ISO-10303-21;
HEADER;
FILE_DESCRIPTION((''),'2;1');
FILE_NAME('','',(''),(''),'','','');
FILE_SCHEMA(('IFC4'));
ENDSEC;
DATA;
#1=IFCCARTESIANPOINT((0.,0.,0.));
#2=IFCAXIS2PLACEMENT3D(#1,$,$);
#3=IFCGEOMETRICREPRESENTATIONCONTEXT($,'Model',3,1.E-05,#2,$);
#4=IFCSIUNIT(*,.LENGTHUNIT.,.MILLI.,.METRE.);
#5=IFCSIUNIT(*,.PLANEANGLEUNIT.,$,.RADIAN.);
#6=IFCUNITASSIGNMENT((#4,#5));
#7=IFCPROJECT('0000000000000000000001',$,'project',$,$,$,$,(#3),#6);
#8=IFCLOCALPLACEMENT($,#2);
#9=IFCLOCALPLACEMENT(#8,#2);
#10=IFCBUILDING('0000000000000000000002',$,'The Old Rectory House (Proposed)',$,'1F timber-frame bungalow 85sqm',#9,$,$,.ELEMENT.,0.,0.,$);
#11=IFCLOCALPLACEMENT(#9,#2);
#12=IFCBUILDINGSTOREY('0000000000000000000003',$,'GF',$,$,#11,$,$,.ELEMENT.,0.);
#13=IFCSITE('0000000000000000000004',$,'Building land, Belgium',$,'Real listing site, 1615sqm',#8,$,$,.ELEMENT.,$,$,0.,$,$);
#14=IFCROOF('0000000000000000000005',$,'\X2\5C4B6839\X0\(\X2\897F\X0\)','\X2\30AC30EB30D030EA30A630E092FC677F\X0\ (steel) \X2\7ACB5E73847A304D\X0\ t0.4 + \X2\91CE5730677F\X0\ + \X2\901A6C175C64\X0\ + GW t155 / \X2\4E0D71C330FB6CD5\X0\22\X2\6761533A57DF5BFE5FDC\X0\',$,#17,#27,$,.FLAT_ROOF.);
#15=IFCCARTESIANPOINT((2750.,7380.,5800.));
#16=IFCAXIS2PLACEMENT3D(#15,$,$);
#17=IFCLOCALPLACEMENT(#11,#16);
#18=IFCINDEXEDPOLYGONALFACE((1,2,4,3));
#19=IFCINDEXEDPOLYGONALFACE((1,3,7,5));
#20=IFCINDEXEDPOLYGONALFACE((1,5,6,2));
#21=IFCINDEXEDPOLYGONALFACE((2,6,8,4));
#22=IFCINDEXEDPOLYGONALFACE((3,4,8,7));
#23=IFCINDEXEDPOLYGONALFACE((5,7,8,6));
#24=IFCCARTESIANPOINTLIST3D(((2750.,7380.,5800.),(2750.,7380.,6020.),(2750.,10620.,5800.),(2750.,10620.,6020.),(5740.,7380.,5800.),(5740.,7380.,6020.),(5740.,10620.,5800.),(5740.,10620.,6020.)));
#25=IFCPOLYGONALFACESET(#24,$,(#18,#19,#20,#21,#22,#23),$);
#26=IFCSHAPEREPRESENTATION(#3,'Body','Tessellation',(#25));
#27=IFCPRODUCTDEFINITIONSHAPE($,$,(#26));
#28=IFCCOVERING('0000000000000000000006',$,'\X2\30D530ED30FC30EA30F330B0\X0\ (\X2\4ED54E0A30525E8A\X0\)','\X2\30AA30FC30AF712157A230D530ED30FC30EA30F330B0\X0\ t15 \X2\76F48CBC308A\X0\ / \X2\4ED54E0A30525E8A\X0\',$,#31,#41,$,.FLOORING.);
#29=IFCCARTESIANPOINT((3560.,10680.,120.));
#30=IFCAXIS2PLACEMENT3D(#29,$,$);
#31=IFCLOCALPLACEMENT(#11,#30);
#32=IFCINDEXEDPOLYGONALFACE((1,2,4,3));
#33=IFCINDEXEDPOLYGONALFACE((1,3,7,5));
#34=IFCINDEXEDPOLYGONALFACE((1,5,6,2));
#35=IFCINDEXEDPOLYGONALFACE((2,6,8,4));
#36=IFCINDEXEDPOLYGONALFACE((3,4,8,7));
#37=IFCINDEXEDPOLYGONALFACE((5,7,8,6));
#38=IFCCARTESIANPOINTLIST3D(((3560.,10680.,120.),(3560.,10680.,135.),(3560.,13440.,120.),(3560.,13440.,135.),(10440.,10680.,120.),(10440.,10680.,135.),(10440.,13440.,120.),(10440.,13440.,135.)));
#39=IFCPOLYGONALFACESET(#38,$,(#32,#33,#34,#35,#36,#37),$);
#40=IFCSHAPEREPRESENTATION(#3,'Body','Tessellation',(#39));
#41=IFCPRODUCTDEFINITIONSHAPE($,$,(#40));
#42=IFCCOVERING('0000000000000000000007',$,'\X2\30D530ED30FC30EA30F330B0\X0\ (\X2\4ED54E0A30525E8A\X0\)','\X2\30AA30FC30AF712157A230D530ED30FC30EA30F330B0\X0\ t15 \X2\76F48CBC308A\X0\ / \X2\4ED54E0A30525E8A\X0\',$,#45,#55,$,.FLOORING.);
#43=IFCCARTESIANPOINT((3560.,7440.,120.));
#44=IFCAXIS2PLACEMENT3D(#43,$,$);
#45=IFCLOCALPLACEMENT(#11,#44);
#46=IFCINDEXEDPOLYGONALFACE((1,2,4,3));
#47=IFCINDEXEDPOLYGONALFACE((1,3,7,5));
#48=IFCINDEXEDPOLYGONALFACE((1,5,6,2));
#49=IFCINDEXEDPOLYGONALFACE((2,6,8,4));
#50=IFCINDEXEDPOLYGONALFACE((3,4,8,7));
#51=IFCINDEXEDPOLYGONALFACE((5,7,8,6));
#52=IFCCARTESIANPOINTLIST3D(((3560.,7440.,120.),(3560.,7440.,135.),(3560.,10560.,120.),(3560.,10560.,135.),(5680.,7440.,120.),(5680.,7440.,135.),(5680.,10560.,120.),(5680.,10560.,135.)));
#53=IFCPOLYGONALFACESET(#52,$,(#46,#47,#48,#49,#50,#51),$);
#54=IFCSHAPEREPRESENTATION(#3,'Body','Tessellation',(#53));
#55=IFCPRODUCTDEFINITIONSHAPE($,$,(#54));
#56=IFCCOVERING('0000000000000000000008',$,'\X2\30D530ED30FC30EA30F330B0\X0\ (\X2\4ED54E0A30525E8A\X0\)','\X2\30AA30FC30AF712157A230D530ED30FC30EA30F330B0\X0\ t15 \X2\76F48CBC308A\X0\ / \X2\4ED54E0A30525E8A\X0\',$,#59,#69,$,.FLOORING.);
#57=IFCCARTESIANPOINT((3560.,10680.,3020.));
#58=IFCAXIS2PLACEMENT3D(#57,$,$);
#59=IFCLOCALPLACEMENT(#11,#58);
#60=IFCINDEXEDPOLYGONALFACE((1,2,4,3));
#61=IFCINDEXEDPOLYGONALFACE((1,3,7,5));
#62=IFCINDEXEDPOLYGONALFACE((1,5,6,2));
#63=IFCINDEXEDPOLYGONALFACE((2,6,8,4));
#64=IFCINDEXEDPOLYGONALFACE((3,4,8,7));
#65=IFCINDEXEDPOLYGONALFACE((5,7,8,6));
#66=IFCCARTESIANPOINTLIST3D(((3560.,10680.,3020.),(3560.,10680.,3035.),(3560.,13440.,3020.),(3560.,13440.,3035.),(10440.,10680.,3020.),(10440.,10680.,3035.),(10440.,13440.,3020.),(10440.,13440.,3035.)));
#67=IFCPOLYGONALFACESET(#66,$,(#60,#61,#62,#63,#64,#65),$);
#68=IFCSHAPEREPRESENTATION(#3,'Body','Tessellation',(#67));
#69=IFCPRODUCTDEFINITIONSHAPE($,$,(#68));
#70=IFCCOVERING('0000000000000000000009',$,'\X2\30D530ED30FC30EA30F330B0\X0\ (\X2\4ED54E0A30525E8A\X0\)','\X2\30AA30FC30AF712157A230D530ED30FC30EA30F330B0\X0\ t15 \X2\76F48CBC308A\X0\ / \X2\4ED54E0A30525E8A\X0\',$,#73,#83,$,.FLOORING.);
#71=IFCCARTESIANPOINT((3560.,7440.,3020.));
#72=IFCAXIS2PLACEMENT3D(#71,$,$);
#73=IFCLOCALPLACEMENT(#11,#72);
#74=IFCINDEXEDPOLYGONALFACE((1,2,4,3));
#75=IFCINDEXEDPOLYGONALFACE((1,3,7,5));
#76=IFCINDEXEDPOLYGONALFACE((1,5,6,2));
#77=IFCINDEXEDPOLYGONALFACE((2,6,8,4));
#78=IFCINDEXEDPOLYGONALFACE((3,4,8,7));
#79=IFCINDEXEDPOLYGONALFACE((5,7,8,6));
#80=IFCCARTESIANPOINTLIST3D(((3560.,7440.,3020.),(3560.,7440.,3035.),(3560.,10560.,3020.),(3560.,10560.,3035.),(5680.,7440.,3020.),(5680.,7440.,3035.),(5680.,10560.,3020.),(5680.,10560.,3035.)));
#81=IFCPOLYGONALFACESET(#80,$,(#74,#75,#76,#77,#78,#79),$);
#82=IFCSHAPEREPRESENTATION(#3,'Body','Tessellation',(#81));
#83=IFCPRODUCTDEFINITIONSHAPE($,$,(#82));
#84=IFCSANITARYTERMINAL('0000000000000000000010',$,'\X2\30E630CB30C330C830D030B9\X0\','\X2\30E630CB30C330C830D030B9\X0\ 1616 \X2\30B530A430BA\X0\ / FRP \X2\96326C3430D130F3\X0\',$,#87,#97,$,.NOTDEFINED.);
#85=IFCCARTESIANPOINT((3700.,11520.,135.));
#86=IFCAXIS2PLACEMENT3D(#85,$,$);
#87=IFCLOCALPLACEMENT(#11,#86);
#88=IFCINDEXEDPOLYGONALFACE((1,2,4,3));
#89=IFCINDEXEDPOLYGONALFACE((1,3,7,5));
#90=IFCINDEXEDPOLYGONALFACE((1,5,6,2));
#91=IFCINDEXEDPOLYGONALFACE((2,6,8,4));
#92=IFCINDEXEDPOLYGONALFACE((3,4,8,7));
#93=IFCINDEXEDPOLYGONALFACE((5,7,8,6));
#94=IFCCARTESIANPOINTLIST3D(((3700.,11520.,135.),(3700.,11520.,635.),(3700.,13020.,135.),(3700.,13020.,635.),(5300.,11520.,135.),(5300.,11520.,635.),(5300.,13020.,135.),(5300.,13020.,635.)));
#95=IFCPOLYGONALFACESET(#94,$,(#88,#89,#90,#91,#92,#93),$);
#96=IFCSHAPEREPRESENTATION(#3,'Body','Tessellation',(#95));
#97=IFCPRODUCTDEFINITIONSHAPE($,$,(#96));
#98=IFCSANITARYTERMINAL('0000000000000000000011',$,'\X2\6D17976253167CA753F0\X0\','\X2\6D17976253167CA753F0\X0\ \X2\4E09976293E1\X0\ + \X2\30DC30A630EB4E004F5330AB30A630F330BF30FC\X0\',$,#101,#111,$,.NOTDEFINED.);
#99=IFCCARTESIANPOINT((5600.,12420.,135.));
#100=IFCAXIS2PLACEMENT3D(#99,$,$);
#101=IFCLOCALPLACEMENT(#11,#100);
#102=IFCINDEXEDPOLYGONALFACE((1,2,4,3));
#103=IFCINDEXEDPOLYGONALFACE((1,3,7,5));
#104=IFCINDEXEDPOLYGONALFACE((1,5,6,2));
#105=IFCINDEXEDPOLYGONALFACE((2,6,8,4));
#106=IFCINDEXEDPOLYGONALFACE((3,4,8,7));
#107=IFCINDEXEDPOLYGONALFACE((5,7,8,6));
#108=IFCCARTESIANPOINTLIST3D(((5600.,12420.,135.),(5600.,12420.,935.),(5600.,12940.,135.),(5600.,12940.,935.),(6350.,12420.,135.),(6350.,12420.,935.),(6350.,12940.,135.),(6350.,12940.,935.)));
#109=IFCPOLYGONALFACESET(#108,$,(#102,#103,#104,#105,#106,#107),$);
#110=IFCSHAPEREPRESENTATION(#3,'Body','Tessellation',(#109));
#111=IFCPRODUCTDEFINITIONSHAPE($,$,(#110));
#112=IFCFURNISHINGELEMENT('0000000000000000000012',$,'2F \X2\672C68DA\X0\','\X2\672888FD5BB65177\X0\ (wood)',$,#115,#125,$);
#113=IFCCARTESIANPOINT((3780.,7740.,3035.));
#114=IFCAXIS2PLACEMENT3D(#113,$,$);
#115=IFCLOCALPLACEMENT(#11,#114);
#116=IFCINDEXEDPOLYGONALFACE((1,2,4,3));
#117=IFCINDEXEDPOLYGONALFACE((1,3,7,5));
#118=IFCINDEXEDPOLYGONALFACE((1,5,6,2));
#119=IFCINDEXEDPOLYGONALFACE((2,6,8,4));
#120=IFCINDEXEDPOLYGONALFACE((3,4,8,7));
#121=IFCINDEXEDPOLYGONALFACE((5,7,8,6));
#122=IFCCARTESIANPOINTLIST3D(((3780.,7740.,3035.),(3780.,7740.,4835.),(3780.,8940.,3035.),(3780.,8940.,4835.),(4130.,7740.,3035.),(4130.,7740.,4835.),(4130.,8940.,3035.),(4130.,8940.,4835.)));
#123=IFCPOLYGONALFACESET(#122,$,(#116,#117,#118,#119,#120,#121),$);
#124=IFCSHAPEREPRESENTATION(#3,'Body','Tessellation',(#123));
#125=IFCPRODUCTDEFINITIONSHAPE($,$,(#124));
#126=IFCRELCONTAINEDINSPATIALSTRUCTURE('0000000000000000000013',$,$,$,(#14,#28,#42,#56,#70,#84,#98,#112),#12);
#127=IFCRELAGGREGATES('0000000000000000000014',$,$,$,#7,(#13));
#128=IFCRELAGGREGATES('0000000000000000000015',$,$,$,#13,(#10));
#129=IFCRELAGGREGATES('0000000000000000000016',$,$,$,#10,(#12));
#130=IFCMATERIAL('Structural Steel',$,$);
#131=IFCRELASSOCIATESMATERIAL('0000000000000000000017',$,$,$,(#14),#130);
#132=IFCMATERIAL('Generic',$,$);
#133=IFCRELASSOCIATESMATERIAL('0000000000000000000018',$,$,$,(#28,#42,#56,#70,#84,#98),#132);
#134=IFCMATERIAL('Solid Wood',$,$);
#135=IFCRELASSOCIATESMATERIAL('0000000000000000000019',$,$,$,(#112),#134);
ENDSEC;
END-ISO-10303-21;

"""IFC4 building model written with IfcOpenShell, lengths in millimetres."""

from ifc_helpers import new_model, si_unit, frame, frame_2d, origin, place, context, project, spatial, rectangle, extrude, material, element, save


model = new_model("IFC4")

# Units and contexts
model_context = context("Model", 3, precision=1e-05, world=origin())
ifc_project = project(units=[si_unit("LENGTHUNIT", "METRE", prefix="MILLI"), si_unit("PLANEANGLEUNIT", "RADIAN")], contexts=[model_context])

# Site, building, storey
site_placement = place(None, origin())
site = spatial("IfcSite", under=ifc_project, at=site_placement, Name="Building land, Belgium", ObjectType="Real listing site, 1615sqm", CompositionType="ELEMENT", RefElevation=0.0)
building_placement = place(site_placement, origin())
building = spatial("IfcBuilding", under=site, at=building_placement, Name="The Old Rectory House (Proposed)", ObjectType="1F timber-frame bungalow 85sqm", CompositionType="ELEMENT", ElevationOfRefHeight=0.0, ElevationOfTerrain=0.0)
storey_placement = place(building_placement, origin())
storey = spatial("IfcBuildingStorey", under=building, at=storey_placement, Name="GF", CompositionType="ELEMENT", Elevation=0.0)

# Shared definitions
ifc_material_1 = material(Name="Solid Wood")

# Roof
ifc_material_2 = material(Name="Structural Steel")
roof_placement = place(storey_placement, frame((2750.0, 7380.0, 5800.0)))
element("IfcRoof", 1, at=roof_placement, inside=storey, material=ifc_material_2, Name="屋根(西)", Description="ガルバリウム鋼板 (steel) 立平葺き t0.4 + 野地板 + 通気層 + GW t155 / 不燃・法22条区域対応", PredefinedType="FLAT_ROOF", context=model_context, shape_type="SweptSolid", body=[
    extrude(rectangle(XDim=2990.0, YDim=3240.0, at=frame_2d((1495.0, 1620.0))), frame((2750.0, 7380.0, 5800.0)), (0.0, 0.0, 1.0), 220.0),
])

# Coverings
ifc_material_3 = material(Name="Generic")
covering_1_placement = place(storey_placement, frame((3560.0, 10680.0, 120.0)))
element("IfcCovering", 2, at=covering_1_placement, inside=storey, material=ifc_material_3, Name="フローリング (仕上げ床)", Description="オーク無垢フローリング t15 直貼り / 仕上げ床", PredefinedType="FLOORING", context=model_context, shape_type="SweptSolid", body=[
    extrude(rectangle(XDim=6880.0, YDim=2760.0, at=frame_2d((3440.0, 1380.0))), frame((3560.0, 10680.0, 120.0)), (0.0, 0.0, 1.0), 15.0),
])
covering_2_placement = place(storey_placement, frame((3560.0, 7440.0, 120.0)))
element("IfcCovering", 3, at=covering_2_placement, inside=storey, material=ifc_material_3, Name="フローリング (仕上げ床)", Description="オーク無垢フローリング t15 直貼り / 仕上げ床", PredefinedType="FLOORING", context=model_context, shape_type="SweptSolid", body=[
    extrude(rectangle(XDim=2120.0, YDim=3120.0, at=frame_2d((1060.0, 1560.0))), frame((3560.0, 7440.0, 120.0)), (0.0, 0.0, 1.0), 15.0),
])
covering_3_placement = place(storey_placement, frame((3560.0, 10680.0, 3020.0)))
element("IfcCovering", 4, at=covering_3_placement, inside=storey, material=ifc_material_3, Name="フローリング (仕上げ床)", Description="オーク無垢フローリング t15 直貼り / 仕上げ床", PredefinedType="FLOORING", context=model_context, shape_type="SweptSolid", body=[
    extrude(rectangle(XDim=6880.0, YDim=2760.0, at=frame_2d((3440.0, 1380.0))), frame((3560.0, 10680.0, 3020.0)), (0.0, 0.0, 1.0), 15.0),
])
covering_4_placement = place(storey_placement, frame((3560.0, 7440.0, 3020.0)))
element("IfcCovering", 5, at=covering_4_placement, inside=storey, material=ifc_material_3, Name="フローリング (仕上げ床)", Description="オーク無垢フローリング t15 直貼り / 仕上げ床", PredefinedType="FLOORING", context=model_context, shape_type="SweptSolid", body=[
    extrude(rectangle(XDim=2120.0, YDim=3120.0, at=frame_2d((1060.0, 1560.0))), frame((3560.0, 7440.0, 3020.0)), (0.0, 0.0, 1.0), 15.0),
])

# Sanitary terminals
sanitary_terminal_1_placement = place(storey_placement, frame((3700.0, 11520.0, 135.0)))
element("IfcSanitaryTerminal", 6, at=sanitary_terminal_1_placement, inside=storey, material=ifc_material_3, Name="ユニットバス", Description="ユニットバス 1616 サイズ / FRP 防水パン", PredefinedType="NOTDEFINED", context=model_context, shape_type="SweptSolid", body=[
    extrude(rectangle(XDim=1600.0, YDim=1500.0, at=frame_2d((800.0, 750.0))), frame((3700.0, 11520.0, 135.0)), (0.0, 0.0, 1.0), 500.0),
])
sanitary_terminal_2_placement = place(storey_placement, frame((5600.0, 12420.0, 135.0)))
element("IfcSanitaryTerminal", 7, at=sanitary_terminal_2_placement, inside=storey, material=ifc_material_3, Name="洗面化粧台", Description="洗面化粧台 三面鏡 + ボウル一体カウンター", PredefinedType="NOTDEFINED", context=model_context, shape_type="SweptSolid", body=[
    extrude(rectangle(XDim=750.0, YDim=520.0, at=frame_2d((375.0, 260.0))), frame((5600.0, 12420.0, 135.0)), (0.0, 0.0, 1.0), 800.0),
])

# Furnishing element
furnishing_placement = place(storey_placement, frame((3780.0, 7740.0, 3035.0)))
element("IfcFurnishingElement", 8, at=furnishing_placement, inside=storey, material=ifc_material_1, Name="2F 本棚", Description="木製家具 (wood)", context=model_context, shape_type="SweptSolid", body=[
    extrude(rectangle(XDim=350.0, YDim=1200.0, at=frame_2d((175.0, 600.0))), frame((3780.0, 7740.0, 3035.0)), (0.0, 0.0, 1.0), 1800.0),
])

save(model, "model.ifc")
